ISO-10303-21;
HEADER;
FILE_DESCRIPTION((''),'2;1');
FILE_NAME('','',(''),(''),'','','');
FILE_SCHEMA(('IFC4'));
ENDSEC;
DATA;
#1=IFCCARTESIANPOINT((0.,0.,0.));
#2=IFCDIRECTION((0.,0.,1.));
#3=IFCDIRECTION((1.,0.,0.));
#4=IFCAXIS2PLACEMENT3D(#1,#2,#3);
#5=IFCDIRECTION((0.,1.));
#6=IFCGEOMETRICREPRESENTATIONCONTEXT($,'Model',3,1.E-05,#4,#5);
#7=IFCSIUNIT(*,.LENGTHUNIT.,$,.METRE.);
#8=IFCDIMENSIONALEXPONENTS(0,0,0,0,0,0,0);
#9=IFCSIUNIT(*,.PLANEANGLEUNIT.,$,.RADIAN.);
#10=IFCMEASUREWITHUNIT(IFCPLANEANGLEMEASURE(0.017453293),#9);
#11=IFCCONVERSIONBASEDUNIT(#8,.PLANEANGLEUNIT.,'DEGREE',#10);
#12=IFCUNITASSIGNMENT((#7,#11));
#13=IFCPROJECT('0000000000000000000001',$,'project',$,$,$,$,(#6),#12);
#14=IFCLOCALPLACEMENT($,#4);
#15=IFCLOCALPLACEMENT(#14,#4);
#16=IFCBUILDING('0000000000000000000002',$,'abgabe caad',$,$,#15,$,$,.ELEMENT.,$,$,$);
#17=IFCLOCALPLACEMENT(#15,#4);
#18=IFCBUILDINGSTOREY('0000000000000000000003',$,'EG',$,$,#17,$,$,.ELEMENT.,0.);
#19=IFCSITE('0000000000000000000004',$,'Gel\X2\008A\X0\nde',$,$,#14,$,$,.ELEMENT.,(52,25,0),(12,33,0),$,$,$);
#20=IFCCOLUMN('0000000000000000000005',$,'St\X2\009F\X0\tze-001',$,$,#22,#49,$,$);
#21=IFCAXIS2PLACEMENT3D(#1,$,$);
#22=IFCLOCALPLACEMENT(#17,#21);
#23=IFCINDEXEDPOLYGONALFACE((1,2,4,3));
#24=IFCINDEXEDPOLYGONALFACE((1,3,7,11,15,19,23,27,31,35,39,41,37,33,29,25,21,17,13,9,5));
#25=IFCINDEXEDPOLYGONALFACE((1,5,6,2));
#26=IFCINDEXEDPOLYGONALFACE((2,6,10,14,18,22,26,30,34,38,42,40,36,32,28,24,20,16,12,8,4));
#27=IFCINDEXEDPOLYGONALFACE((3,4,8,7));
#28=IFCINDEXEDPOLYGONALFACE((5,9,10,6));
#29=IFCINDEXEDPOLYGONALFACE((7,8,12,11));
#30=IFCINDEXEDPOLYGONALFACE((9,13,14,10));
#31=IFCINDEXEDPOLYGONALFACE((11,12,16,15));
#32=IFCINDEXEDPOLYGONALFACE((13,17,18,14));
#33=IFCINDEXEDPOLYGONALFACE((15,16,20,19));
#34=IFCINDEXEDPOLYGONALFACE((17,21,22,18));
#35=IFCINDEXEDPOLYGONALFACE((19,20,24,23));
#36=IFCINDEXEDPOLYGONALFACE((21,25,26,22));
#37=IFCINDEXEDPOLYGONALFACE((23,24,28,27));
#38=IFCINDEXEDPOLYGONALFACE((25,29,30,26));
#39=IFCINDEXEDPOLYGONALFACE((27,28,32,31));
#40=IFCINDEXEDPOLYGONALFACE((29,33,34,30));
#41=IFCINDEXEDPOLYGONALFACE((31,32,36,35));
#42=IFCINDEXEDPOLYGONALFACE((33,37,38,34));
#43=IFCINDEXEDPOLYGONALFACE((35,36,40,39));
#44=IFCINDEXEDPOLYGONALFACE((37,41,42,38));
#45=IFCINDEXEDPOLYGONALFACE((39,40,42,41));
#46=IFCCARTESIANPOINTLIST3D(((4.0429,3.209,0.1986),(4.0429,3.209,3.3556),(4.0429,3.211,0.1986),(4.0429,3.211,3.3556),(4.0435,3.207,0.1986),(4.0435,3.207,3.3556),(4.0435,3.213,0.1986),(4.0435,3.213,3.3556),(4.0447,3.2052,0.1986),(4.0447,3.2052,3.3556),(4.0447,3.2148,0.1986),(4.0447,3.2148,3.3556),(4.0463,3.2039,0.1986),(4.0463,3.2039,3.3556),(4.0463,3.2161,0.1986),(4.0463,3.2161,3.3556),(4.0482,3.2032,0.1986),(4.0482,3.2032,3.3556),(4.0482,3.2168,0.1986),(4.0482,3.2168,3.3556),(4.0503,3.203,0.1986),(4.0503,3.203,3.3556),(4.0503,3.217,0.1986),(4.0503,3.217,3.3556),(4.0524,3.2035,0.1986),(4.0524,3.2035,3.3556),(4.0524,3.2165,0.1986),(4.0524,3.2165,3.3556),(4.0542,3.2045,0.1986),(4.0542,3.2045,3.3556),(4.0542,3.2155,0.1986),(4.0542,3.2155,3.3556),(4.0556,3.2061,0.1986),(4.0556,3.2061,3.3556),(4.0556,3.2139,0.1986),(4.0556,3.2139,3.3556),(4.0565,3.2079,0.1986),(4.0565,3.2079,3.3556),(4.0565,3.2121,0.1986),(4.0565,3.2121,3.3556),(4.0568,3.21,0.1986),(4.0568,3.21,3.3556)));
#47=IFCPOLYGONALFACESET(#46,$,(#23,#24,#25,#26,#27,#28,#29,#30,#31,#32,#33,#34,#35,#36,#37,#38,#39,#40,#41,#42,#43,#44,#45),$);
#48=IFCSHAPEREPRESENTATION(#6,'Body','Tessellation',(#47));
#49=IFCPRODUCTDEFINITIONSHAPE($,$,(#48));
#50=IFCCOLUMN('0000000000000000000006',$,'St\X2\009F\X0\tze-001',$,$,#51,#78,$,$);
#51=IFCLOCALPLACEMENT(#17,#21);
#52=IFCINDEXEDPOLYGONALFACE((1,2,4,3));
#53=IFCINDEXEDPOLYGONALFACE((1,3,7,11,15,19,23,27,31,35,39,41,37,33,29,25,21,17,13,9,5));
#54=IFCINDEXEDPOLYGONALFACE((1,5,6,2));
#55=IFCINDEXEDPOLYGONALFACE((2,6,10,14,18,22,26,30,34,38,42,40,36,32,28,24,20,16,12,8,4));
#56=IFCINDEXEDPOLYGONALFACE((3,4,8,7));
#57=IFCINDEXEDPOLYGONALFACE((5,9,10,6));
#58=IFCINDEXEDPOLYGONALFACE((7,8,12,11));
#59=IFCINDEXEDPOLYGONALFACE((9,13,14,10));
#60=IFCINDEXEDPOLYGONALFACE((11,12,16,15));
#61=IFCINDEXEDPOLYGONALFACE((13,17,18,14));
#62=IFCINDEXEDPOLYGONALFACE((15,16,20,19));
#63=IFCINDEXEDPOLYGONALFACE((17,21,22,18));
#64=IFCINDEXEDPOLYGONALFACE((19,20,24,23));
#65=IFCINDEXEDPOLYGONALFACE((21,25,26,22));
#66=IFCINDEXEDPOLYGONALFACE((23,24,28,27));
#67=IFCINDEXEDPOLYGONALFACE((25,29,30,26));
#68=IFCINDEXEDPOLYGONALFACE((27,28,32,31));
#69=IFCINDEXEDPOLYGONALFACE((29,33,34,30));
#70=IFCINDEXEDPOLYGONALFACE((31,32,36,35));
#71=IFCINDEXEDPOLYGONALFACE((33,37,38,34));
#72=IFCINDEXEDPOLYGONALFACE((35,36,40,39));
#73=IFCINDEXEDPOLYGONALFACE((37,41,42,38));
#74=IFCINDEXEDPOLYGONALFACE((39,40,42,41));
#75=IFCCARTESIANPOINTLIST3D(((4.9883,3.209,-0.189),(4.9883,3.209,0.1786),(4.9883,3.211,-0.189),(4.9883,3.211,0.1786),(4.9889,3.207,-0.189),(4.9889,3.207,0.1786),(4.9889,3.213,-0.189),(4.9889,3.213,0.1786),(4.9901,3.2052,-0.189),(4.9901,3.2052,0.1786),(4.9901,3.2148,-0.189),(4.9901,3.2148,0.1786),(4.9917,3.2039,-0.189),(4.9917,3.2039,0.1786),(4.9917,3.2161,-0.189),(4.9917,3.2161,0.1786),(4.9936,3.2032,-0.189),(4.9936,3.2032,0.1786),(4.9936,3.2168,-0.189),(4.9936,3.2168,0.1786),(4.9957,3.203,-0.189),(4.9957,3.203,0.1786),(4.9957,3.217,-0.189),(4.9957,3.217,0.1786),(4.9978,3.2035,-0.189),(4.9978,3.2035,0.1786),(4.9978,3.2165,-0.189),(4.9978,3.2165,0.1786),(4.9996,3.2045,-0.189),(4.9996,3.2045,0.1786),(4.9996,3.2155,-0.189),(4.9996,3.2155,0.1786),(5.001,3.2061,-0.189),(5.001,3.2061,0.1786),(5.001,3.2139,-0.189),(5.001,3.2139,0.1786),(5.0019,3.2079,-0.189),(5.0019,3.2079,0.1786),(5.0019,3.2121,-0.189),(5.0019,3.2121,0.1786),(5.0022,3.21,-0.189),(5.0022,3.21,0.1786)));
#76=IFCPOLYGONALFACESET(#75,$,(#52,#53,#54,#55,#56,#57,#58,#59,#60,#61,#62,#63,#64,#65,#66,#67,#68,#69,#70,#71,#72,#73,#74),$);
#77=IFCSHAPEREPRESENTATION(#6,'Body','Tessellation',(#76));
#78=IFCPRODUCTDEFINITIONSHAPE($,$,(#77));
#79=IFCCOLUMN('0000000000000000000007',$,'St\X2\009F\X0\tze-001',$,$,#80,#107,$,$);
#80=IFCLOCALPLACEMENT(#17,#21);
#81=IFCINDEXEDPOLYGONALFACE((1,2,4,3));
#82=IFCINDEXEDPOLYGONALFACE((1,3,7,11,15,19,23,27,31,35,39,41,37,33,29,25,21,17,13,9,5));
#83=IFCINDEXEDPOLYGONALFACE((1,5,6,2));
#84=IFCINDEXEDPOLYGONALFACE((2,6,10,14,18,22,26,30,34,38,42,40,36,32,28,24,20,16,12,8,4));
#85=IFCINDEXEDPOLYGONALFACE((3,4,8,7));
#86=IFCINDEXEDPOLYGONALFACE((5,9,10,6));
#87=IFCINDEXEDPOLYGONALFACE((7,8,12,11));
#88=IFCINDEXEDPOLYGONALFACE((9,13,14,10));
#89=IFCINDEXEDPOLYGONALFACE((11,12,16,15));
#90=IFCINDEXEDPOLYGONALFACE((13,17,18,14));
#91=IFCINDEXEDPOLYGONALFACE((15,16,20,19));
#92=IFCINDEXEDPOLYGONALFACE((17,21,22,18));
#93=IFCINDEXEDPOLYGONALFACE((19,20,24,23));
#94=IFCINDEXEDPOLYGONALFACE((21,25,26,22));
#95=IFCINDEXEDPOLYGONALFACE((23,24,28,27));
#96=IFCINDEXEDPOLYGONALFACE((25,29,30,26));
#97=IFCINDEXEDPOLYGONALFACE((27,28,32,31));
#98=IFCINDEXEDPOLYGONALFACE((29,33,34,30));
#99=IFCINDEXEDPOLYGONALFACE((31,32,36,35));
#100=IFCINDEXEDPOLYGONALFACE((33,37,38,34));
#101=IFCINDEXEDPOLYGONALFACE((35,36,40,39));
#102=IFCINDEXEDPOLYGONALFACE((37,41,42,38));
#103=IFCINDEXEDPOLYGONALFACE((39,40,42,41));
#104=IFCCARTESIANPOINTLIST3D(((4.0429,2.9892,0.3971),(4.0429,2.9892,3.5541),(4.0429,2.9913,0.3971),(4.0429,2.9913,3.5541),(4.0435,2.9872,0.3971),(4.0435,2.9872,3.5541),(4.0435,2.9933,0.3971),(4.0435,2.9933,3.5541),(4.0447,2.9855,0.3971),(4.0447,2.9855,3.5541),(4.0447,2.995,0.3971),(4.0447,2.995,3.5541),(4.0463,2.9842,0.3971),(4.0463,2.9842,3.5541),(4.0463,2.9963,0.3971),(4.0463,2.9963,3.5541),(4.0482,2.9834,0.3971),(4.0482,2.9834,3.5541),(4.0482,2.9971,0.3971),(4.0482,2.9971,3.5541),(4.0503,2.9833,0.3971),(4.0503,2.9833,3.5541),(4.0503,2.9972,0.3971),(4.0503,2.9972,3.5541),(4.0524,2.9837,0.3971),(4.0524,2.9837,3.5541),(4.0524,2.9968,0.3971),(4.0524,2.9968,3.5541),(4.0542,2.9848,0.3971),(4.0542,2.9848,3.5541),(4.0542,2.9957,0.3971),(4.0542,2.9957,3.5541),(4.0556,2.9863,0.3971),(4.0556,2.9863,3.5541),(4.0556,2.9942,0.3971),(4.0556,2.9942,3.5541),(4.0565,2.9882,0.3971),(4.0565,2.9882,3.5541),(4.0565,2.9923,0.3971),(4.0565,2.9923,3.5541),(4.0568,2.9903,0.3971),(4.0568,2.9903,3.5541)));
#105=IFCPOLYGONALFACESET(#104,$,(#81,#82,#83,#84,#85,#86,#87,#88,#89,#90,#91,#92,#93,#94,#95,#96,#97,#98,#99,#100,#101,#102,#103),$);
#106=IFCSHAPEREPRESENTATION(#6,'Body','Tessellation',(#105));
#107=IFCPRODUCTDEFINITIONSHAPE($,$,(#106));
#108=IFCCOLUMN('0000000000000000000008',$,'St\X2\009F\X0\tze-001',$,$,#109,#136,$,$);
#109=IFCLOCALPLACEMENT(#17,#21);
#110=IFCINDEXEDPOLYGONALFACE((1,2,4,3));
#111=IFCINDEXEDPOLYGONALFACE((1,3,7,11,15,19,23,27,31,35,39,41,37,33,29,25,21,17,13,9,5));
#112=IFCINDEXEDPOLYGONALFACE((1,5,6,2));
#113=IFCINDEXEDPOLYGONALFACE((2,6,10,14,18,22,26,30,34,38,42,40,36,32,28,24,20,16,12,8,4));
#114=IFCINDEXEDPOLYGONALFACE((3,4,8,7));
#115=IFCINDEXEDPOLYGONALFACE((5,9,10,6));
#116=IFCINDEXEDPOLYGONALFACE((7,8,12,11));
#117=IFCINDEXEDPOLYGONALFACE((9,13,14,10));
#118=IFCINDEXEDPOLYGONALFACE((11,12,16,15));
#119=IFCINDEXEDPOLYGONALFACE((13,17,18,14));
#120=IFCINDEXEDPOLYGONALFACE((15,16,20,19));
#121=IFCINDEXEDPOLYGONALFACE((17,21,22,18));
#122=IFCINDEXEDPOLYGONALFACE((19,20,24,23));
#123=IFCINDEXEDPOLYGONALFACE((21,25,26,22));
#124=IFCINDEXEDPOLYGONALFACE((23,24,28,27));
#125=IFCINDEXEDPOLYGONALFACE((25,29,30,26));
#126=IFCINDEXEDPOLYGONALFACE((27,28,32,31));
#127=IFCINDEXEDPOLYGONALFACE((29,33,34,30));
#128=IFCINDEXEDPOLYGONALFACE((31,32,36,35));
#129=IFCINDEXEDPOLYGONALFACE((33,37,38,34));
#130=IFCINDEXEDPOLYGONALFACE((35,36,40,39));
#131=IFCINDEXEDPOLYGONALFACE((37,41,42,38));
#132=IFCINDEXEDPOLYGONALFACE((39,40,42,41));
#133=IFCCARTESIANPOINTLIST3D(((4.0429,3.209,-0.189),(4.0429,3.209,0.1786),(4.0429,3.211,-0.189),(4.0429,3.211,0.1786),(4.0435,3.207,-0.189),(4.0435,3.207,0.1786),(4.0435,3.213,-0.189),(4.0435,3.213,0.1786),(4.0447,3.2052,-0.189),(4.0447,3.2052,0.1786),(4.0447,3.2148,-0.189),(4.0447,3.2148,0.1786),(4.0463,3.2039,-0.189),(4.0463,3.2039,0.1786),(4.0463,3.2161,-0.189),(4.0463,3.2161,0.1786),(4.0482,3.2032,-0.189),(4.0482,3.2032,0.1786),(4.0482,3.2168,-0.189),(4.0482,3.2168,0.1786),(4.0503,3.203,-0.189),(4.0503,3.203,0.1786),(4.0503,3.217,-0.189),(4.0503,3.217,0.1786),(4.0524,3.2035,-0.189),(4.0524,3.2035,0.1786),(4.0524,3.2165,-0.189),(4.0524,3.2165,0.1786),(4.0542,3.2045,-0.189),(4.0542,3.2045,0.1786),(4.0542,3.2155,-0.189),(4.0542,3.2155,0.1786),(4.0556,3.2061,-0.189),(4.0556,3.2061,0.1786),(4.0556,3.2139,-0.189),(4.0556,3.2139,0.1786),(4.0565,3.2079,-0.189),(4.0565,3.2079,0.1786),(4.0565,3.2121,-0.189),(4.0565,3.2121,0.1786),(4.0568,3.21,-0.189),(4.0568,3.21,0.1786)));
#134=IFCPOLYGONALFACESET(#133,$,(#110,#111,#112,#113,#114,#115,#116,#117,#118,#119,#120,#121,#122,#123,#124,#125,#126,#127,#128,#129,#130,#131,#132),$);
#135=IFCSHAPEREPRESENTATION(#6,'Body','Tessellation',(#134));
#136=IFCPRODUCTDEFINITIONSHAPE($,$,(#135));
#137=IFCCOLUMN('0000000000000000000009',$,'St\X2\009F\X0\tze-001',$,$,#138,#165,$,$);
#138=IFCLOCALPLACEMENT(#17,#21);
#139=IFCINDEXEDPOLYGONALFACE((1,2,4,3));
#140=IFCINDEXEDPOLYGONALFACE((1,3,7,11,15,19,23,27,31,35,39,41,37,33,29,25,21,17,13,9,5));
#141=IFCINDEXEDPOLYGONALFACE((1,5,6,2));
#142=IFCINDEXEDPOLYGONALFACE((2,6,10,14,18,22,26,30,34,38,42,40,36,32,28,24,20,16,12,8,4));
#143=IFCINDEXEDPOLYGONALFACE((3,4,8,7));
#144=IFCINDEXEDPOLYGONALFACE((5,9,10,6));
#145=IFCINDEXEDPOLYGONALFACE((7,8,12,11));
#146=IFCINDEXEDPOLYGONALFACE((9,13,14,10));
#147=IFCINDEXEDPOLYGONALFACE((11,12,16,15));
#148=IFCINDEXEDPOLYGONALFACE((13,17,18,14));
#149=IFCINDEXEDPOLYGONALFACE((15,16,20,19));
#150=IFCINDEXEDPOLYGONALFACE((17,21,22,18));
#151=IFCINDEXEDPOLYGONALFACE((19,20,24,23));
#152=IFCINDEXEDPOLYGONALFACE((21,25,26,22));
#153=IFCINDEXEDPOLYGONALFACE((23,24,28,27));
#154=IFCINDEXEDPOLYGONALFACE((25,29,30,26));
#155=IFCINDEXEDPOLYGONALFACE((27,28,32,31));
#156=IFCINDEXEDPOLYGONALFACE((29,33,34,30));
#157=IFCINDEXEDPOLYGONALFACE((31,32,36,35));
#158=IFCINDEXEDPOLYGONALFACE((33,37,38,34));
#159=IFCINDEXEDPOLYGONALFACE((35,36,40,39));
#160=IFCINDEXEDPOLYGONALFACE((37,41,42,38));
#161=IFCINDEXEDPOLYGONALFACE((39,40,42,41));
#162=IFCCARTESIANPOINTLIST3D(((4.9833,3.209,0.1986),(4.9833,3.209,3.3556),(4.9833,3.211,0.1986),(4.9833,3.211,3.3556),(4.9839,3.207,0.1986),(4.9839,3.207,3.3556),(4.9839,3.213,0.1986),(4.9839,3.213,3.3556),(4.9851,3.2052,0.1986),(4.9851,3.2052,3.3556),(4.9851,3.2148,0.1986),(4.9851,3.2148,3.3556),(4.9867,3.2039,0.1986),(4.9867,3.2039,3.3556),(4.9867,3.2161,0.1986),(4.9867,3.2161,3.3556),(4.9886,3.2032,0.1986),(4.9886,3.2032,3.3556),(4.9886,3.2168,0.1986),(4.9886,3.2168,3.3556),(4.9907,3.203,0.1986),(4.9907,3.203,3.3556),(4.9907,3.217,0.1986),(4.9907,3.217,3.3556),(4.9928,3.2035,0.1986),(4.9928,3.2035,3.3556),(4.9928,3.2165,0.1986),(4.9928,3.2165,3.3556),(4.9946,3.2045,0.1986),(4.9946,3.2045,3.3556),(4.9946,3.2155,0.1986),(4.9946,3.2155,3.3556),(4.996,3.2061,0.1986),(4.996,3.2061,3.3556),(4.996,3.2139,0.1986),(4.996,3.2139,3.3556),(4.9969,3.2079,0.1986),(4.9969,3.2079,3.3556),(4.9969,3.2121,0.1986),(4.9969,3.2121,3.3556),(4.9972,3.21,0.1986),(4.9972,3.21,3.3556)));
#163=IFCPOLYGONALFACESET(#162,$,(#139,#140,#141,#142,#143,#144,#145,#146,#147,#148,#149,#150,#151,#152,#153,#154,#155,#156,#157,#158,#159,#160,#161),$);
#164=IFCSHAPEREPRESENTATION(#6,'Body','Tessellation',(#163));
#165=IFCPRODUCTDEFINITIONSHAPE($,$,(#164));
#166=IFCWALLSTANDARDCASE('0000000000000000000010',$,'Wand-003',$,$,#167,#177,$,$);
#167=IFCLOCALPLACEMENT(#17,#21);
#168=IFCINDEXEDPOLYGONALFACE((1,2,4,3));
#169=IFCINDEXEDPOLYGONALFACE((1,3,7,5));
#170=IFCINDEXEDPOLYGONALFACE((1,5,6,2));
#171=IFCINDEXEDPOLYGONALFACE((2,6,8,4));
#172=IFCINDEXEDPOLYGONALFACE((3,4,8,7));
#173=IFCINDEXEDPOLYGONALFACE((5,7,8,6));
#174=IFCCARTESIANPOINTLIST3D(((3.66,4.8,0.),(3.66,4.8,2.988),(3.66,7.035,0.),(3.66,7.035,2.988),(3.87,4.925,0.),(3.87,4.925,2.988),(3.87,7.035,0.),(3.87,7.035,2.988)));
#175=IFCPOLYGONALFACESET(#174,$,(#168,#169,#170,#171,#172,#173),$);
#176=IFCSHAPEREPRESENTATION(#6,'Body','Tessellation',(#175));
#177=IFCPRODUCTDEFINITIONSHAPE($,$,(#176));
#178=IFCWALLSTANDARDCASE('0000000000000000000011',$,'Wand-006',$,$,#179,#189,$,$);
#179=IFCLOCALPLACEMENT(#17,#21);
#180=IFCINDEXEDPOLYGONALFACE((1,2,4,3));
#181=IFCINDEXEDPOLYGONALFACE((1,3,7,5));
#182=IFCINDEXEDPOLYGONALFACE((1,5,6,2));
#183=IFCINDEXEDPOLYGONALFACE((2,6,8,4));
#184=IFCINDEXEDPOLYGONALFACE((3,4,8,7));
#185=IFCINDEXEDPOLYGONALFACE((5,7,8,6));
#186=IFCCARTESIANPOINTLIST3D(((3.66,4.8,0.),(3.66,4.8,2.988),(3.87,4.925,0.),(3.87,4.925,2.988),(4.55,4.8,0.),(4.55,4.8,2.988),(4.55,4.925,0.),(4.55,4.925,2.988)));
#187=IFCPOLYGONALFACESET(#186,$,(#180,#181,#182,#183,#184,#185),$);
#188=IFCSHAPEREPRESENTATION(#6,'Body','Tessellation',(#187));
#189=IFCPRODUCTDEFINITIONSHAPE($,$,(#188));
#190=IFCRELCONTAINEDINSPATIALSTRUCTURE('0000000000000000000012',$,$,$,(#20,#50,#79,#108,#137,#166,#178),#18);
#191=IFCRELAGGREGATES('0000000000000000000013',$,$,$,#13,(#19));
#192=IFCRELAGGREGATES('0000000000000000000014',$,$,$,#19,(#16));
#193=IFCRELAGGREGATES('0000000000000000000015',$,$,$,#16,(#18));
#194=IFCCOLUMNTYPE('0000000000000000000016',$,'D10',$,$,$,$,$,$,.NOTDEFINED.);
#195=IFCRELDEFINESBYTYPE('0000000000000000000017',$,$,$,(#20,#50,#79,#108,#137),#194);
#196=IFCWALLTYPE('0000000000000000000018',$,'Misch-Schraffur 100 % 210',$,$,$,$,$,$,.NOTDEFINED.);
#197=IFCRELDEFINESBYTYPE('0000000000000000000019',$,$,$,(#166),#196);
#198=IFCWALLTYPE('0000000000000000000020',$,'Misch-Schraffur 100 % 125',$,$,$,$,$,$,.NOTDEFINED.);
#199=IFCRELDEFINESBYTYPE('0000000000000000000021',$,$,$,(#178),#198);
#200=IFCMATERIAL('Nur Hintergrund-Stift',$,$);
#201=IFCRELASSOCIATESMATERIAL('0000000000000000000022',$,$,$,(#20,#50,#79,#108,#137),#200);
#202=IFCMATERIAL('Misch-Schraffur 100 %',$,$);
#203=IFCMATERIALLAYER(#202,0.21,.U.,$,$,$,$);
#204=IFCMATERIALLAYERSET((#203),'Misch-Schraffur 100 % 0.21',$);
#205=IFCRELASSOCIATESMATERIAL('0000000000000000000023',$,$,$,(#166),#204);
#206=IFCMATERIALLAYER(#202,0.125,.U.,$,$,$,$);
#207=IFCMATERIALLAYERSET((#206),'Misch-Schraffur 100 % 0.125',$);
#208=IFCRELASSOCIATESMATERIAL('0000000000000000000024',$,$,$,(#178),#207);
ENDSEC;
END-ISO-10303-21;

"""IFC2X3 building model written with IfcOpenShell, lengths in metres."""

from ifc_helpers import new_model, entity, si_unit, converted_unit, direction, frame, origin_with_axes, origin_2d_with_axis, place, context, project, spatial, polyline, circle, outline, extrude, material, layer, layer_set, layer_usage, type_object, element, save


model = new_model("IFC2X3")

# Units and contexts
model_context = context("Model", 3, precision=1e-05, world=origin_with_axes(), true_north=direction((0.0, 1.0)))
ifc_project = project(units=[si_unit("LENGTHUNIT", "METRE"), converted_unit("PLANEANGLEUNIT", "DEGREE", entity("IfcPlaneAngleMeasure", 0.017453293), si_unit("PLANEANGLEUNIT", "RADIAN"), dimensions=[0, 0, 0, 0, 0, 0, 0])], contexts=[model_context])

# Site, building, storey
site_placement = place(None, origin_with_axes())
site = spatial("IfcSite", under=ifc_project, at=site_placement, Name="Gel\u008ande", CompositionType="ELEMENT", RefLatitude=(52, 25, 0), RefLongitude=(12, 33, 0))
building_placement = place(site_placement, origin_with_axes())
building = spatial("IfcBuilding", under=site, at=building_placement, Name="abgabe caad", CompositionType="ELEMENT")
storey_placement = place(building_placement, origin_with_axes())
storey = spatial("IfcBuildingStorey", under=building, at=storey_placement, Name="EG", CompositionType="ELEMENT", Elevation=0.0)

# Columns
ifc_material_1 = material(Name="Nur Hintergrund-Stift")
column_type = type_object("IfcColumnType", Name="D10", PredefinedType="NOTDEFINED")
column_1_placement = place(storey_placement, frame((4.0498, 3.21, 0.1986), z_axis=(0.0, 0.0, 1.0), x_axis=(1.0, 0.0, 0.0)))
element("IfcColumn", 1, at=column_1_placement, inside=storey, type_object=column_type, material=ifc_material_1, Name="St\u009ftze-001", context=model_context, shape_type="SweptSolid", body=[
    extrude(circle(Radius=0.007, at=origin_2d_with_axis()), origin_with_axes(), (0.0, 0.0, 1.0), 3.157),
])
column_2_placement = place(storey_placement, frame((4.9952, 3.21, -0.189), z_axis=(0.0, 0.0, 1.0), x_axis=(1.0, 0.0, 0.0)))
element("IfcColumn", 2, at=column_2_placement, inside=storey, type_object=column_type, material=ifc_material_1, Name="St\u009ftze-001", context=model_context, shape_type="SweptSolid", body=[
    extrude(circle(Radius=0.007, at=origin_2d_with_axis()), origin_with_axes(), (0.0, 0.0, 1.0), 0.3676),
])
column_3_placement = place(storey_placement, frame((4.0498, 2.9903, 0.3971), z_axis=(0.0, 0.0, 1.0), x_axis=(1.0, 0.0, 0.0)))
element("IfcColumn", 3, at=column_3_placement, inside=storey, type_object=column_type, material=ifc_material_1, Name="St\u009ftze-001", context=model_context, shape_type="SweptSolid", body=[
    extrude(circle(Radius=0.007, at=origin_2d_with_axis()), origin_with_axes(), (0.0, 0.0, 1.0), 3.157),
])
column_4_placement = place(storey_placement, frame((4.0498, 3.21, -0.189), z_axis=(0.0, 0.0, 1.0), x_axis=(1.0, 0.0, 0.0)))
element("IfcColumn", 4, at=column_4_placement, inside=storey, type_object=column_type, material=ifc_material_1, Name="St\u009ftze-001", context=model_context, shape_type="SweptSolid", body=[
    extrude(circle(Radius=0.007, at=origin_2d_with_axis()), origin_with_axes(), (0.0, 0.0, 1.0), 0.3676),
])
column_5_placement = place(storey_placement, frame((4.9902, 3.21, 0.1986), z_axis=(0.0, 0.0, 1.0), x_axis=(1.0, 0.0, 0.0)))
element("IfcColumn", 5, at=column_5_placement, inside=storey, type_object=column_type, material=ifc_material_1, Name="St\u009ftze-001", context=model_context, shape_type="SweptSolid", body=[
    extrude(circle(Radius=0.007, at=origin_2d_with_axis()), origin_with_axes(), (0.0, 0.0, 1.0), 3.157),
])

# Walls
ifc_material_2 = material(Name="Misch-Schraffur 100 %")
ifc_layer_1 = layer(ifc_material_2, 0.21, ventilated="UNKNOWN")
ifc_layer_set_1 = layer_set([ifc_layer_1], Name="Misch-Schraffur 100 % 0.21")
ifc_layer_usage_1 = layer_usage(ifc_layer_set_1, "AXIS2", "NEGATIVE", 0.0)
wall_type_1 = type_object("IfcWallType", Name="Misch-Schraffur 100 % 210", PredefinedType="NOTDEFINED")
wall_1_placement = place(storey_placement, frame((3.66, 4.8, 0.0), z_axis=(0.0, 0.0, 1.0), x_axis=(0.0, 1.0, 0.0)))
element("IfcWallStandardCase", 6, at=wall_1_placement, inside=storey, type_object=wall_type_1, material=ifc_layer_usage_1, Name="Wand-003", context=model_context, shape_type="SweptSolid", body=[
    extrude(outline(polyline([(0.125, -0.21), (2.235, -0.21), (2.235, 0.0), (0.0, 0.0), (0.125, -0.21)])), origin_with_axes(), (0.0, 0.0, 1.0), 2.988),
])
ifc_layer_2 = layer(ifc_material_2, 0.125, ventilated="UNKNOWN")
ifc_layer_set_2 = layer_set([ifc_layer_2], Name="Misch-Schraffur 100 % 0.125")
ifc_layer_usage_2 = layer_usage(ifc_layer_set_2, "AXIS2", "POSITIVE", 0.0)
wall_type_2 = type_object("IfcWallType", Name="Misch-Schraffur 100 % 125", PredefinedType="NOTDEFINED")
wall_2_placement = place(storey_placement, frame((3.66, 4.8, 0.0), z_axis=(0.0, 0.0, 1.0), x_axis=(1.0, 0.0, 0.0)))
element("IfcWallStandardCase", 7, at=wall_2_placement, inside=storey, type_object=wall_type_2, material=ifc_layer_usage_2, Name="Wand-006", context=model_context, shape_type="SweptSolid", body=[
    extrude(outline(polyline([(0.0, 0.0), (0.89, 0.0), (0.89, 0.125), (0.21, 0.125), (0.0, 0.0)])), origin_with_axes(), (0.0, 0.0, 1.0), 2.988),
])

save(model, "model.ifc")
